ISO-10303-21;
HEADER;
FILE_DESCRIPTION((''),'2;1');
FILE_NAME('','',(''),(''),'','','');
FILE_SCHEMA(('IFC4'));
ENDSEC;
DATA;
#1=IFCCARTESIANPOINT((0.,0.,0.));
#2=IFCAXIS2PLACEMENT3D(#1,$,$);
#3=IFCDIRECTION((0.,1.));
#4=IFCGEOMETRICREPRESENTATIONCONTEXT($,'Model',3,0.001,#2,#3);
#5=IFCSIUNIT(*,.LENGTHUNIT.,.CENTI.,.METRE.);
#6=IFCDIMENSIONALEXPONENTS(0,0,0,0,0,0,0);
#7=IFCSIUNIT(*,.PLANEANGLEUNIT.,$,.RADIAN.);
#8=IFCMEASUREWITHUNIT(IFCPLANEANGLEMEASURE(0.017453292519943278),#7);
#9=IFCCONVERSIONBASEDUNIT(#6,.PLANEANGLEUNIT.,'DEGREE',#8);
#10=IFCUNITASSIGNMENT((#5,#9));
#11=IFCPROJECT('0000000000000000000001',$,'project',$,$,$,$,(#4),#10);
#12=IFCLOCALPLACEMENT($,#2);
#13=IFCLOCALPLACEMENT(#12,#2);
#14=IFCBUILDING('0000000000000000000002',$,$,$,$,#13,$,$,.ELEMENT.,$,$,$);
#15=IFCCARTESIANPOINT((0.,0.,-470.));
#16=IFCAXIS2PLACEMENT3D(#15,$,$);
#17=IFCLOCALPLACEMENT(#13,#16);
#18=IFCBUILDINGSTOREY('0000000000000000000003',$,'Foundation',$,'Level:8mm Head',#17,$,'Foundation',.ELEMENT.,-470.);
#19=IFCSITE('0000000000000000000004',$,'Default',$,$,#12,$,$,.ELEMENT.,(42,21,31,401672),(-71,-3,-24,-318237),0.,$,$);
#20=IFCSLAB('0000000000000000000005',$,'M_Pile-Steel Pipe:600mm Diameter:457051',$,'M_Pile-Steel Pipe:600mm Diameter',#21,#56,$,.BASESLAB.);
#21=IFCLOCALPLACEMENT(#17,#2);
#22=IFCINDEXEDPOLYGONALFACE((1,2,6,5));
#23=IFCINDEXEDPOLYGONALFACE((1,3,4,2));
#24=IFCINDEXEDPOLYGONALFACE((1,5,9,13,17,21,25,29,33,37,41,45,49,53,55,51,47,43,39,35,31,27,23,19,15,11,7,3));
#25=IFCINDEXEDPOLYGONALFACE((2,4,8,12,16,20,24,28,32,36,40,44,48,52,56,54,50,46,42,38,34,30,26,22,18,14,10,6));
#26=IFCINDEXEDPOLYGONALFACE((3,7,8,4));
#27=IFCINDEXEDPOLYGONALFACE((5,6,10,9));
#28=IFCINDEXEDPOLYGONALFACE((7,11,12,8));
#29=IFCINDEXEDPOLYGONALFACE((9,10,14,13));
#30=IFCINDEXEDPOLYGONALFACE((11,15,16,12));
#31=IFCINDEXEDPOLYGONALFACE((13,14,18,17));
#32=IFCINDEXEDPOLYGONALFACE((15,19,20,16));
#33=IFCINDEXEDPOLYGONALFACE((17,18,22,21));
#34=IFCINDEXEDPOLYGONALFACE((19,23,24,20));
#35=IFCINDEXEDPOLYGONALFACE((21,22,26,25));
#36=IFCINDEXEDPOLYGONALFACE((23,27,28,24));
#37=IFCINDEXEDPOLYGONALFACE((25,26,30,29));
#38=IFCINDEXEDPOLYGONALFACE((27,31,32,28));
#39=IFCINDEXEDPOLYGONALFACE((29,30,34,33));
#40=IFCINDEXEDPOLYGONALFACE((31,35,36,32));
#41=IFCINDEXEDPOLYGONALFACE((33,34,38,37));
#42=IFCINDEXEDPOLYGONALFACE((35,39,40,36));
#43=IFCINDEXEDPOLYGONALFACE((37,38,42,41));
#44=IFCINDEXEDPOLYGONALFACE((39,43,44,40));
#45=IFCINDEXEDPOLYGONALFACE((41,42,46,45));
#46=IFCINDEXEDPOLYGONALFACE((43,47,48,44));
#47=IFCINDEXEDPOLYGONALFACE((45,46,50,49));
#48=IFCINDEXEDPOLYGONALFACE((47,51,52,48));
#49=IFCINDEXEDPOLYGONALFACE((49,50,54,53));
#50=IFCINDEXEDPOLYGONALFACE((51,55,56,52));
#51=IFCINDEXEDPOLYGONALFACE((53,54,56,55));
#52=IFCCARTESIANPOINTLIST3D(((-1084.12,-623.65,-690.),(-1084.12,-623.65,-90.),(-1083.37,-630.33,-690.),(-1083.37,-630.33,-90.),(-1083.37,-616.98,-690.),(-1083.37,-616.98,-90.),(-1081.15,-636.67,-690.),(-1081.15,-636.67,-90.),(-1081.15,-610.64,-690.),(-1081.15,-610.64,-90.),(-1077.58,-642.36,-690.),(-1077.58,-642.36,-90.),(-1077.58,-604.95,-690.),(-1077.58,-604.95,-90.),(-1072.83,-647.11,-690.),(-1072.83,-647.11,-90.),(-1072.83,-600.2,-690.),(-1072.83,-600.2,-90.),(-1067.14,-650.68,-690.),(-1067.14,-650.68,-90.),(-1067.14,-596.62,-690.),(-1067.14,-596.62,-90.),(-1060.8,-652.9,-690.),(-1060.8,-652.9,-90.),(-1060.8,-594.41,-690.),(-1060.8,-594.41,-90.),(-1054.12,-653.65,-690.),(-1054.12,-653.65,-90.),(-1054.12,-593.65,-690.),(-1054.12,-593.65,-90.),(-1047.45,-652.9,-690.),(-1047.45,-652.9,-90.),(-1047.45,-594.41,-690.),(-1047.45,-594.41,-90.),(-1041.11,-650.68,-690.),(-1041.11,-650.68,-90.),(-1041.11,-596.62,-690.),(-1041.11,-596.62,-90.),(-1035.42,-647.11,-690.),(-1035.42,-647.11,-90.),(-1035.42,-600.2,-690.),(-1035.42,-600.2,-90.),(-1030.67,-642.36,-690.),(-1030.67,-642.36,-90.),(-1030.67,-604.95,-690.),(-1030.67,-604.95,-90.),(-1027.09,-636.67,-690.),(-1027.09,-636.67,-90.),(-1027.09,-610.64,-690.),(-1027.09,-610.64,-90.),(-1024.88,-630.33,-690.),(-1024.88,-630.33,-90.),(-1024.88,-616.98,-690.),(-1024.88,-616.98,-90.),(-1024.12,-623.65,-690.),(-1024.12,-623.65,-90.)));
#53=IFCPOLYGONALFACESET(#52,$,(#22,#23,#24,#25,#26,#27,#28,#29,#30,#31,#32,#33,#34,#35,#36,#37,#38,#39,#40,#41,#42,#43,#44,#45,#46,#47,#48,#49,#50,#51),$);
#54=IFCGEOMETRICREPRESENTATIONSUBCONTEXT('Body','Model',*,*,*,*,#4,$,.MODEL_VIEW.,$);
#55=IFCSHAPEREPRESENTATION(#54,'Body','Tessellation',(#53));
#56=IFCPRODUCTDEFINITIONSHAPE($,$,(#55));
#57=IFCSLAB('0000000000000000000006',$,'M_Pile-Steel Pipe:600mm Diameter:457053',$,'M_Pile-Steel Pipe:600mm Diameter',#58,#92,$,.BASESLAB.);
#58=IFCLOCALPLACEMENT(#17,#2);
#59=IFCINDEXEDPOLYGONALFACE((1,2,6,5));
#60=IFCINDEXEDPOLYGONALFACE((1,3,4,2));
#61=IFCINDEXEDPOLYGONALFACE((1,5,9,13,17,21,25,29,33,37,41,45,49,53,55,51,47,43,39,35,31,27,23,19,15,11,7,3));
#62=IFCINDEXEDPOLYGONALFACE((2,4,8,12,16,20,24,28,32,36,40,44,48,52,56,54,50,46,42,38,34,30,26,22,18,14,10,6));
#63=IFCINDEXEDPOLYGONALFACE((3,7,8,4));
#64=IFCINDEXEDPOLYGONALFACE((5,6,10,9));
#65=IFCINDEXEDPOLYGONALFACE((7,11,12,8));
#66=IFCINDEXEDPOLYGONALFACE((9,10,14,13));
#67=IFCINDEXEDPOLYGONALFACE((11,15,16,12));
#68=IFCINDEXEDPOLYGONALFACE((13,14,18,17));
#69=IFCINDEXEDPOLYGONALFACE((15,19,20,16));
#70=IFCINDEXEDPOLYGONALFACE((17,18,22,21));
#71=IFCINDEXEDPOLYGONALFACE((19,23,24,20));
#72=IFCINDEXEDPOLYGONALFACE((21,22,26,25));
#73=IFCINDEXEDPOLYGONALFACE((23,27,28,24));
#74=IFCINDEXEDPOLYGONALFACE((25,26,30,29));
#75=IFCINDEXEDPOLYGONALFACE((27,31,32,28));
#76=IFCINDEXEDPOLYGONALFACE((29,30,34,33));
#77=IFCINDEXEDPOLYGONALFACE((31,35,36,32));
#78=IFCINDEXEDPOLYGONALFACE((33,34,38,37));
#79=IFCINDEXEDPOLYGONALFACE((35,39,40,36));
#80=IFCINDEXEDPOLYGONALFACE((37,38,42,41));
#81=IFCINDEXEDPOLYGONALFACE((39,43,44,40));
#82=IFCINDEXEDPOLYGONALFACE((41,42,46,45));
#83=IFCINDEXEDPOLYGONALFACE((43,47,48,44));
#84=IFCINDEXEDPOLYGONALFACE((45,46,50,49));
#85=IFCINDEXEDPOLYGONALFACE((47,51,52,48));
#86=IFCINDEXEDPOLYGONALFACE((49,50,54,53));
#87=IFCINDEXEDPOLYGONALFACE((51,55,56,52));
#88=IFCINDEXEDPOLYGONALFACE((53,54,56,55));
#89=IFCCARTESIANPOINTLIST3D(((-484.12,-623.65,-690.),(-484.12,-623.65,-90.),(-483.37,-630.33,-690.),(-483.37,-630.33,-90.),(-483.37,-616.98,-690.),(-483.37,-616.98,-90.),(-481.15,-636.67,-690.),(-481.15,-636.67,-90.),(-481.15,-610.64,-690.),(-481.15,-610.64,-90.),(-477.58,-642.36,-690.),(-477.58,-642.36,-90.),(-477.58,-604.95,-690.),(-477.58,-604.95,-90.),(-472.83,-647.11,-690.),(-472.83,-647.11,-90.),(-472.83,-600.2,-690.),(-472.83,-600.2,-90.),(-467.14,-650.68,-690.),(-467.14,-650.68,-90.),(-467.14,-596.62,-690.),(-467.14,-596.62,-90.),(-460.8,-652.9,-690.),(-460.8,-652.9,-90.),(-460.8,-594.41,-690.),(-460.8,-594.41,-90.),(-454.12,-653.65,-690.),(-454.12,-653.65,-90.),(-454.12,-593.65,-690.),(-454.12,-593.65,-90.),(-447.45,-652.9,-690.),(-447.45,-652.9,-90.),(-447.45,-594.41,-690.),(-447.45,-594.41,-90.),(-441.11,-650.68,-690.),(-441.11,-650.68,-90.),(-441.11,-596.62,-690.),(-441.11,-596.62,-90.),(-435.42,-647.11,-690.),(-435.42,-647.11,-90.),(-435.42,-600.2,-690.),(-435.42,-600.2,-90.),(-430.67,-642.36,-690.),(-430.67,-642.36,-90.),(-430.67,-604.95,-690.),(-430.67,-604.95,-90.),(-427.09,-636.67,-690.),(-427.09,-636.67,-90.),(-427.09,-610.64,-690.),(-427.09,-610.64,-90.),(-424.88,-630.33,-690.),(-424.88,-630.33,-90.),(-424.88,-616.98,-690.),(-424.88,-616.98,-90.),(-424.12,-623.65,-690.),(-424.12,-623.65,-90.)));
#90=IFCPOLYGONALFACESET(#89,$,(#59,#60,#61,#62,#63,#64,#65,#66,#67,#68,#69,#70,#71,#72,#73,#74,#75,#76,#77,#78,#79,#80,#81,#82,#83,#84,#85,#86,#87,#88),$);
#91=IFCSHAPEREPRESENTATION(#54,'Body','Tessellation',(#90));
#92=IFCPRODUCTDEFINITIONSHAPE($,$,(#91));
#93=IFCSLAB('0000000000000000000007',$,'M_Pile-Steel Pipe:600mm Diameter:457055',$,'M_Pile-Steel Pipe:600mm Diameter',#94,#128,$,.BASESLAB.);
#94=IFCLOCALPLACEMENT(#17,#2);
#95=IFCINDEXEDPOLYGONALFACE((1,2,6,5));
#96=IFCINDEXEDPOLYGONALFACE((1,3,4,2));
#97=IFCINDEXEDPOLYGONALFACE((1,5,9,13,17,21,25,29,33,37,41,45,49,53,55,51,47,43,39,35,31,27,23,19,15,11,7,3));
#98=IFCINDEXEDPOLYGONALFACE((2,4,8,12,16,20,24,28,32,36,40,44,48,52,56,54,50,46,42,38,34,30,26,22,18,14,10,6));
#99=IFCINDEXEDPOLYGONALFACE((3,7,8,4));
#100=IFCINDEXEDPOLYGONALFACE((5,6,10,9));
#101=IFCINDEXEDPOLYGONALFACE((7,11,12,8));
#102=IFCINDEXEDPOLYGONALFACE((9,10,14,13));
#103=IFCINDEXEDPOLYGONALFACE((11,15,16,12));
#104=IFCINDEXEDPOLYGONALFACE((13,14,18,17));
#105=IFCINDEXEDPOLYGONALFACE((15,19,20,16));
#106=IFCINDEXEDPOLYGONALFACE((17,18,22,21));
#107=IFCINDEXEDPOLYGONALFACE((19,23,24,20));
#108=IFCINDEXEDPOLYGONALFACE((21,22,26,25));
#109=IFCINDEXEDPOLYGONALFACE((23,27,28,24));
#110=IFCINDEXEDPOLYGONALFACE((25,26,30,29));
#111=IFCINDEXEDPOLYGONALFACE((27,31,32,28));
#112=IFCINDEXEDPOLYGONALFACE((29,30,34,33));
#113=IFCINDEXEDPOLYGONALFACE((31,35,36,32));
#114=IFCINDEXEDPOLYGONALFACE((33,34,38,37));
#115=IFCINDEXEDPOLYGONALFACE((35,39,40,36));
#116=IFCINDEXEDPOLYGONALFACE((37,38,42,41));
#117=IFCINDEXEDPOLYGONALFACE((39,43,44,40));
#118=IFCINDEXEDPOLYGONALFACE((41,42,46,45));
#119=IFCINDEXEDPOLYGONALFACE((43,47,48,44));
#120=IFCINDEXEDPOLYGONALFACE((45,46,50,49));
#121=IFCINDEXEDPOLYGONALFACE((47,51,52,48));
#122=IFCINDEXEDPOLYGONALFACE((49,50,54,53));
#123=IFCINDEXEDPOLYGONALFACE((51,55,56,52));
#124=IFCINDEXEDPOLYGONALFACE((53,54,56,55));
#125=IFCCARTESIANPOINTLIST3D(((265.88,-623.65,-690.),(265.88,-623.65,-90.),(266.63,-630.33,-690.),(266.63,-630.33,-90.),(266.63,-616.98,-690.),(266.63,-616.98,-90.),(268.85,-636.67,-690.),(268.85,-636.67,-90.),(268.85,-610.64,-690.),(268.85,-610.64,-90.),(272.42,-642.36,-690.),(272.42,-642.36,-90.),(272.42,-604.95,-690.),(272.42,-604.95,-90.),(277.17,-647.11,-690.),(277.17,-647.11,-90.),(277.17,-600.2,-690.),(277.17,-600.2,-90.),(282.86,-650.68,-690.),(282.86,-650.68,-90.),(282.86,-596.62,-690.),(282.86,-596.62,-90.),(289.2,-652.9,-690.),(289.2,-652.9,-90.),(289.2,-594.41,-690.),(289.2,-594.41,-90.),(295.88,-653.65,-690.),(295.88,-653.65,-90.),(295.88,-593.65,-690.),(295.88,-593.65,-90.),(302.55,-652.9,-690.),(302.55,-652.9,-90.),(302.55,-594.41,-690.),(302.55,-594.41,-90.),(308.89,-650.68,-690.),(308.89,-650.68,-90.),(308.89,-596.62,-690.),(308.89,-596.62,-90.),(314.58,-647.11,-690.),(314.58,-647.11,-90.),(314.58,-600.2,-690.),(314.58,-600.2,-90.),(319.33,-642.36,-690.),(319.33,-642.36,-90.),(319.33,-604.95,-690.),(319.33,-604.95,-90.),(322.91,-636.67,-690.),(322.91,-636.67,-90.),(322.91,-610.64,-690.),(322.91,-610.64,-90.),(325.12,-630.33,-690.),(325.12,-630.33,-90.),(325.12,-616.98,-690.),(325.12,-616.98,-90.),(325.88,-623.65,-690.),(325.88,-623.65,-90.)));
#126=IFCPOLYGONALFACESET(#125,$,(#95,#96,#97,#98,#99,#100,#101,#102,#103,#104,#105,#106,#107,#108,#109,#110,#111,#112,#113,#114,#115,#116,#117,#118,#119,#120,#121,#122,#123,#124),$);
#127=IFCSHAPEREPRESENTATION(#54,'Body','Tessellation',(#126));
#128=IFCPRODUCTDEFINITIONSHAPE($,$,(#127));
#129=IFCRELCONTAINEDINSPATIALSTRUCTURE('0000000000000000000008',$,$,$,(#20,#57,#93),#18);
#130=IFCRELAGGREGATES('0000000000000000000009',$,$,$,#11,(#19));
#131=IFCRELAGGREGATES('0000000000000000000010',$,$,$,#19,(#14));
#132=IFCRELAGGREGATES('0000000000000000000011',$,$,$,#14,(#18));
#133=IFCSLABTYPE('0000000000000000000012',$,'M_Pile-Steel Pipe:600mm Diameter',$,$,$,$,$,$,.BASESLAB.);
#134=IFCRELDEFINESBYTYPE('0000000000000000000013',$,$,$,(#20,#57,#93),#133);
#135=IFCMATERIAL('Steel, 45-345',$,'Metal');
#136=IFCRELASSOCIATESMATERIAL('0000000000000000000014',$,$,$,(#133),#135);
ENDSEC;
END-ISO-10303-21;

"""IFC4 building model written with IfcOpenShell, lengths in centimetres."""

from ifc_helpers import new_model, entity, si_unit, converted_unit, direction, frame, origin, place, context, subcontext, project, spatial, arc, indexed_curve, outline, extrude, material, type_object, element, save


model = new_model("IFC4")

# Units and contexts
model_context = context("Model", 3, precision=0.001, world=origin(), true_north=direction((0.0, 1.0)))
body_context = subcontext(model_context, "Body", "Model", "MODEL_VIEW")
ifc_project = project(units=[si_unit("LENGTHUNIT", "METRE", prefix="CENTI"), converted_unit("PLANEANGLEUNIT", "DEGREE", entity("IfcPlaneAngleMeasure", 0.017453292519943278), si_unit("PLANEANGLEUNIT", "RADIAN"), dimensions=[0, 0, 0, 0, 0, 0, 0])], contexts=[model_context])

# Site, building, storey
site_placement = place(None, origin())
site = spatial("IfcSite", under=ifc_project, at=site_placement, Name="Default", CompositionType="ELEMENT", RefLatitude=(42, 21, 31, 401672), RefLongitude=(-71, -3, -24, -318237), RefElevation=0.0)
building_placement = place(site_placement, origin())
building = spatial("IfcBuilding", under=site, at=building_placement, CompositionType="ELEMENT")
storey_placement = place(building_placement, frame((0.0, 0.0, -470.0)))
storey = spatial("IfcBuildingStorey", under=building, at=storey_placement, Name="Foundation", ObjectType="Level:8mm Head", LongName="Foundation", CompositionType="ELEMENT", Elevation=-470.0)

# Slabs
ifc_material_1 = material(Name="Steel, 45-345", Category="Metal")
slab_type_1 = type_object("IfcSlabType", Name="M_Pile-Steel Pipe:600mm Diameter", PredefinedType="BASESLAB", material=ifc_material_1)
slab_1_placement = place(storey_placement, origin())
element("IfcSlab", 1, at=slab_1_placement, inside=storey, type_object=slab_type_1, Name="M_Pile-Steel Pipe:600mm Diameter:457051", ObjectType="M_Pile-Steel Pipe:600mm Diameter", PredefinedType="BASESLAB", context=body_context, shape_type="SweptSolid", body=[
    extrude(outline(indexed_curve([(-30.0, 0.0), (0.0, -30.0), (30.0, 0.0), (0.0, 30.0)], segments=[arc(1, 2, 3), arc(3, 4, 1)], self_intersect=False)), frame((-1054.12, -623.65, -690.0)), (0.0, 0.0, 1.0), 600.0),
])
slab_2_placement = place(storey_placement, origin())
element("IfcSlab", 2, at=slab_2_placement, inside=storey, type_object=slab_type_1, Name="M_Pile-Steel Pipe:600mm Diameter:457053", ObjectType="M_Pile-Steel Pipe:600mm Diameter", PredefinedType="BASESLAB", context=body_context, shape_type="SweptSolid", body=[
    extrude(outline(indexed_curve([(-30.0, 0.0), (0.0, -30.0), (30.0, 0.0), (0.0, 30.0)], segments=[arc(1, 2, 3), arc(3, 4, 1)], self_intersect=False)), frame((-454.12, -623.65, -690.0)), (0.0, 0.0, 1.0), 600.0),
])
slab_3_placement = place(storey_placement, origin())
element("IfcSlab", 3, at=slab_3_placement, inside=storey, type_object=slab_type_1, Name="M_Pile-Steel Pipe:600mm Diameter:457055", ObjectType="M_Pile-Steel Pipe:600mm Diameter", PredefinedType="BASESLAB", context=body_context, shape_type="SweptSolid", body=[
    extrude(outline(indexed_curve([(-30.0, 0.0), (0.0, -30.0), (30.0, 0.0), (0.0, 30.0)], segments=[arc(1, 2, 3), arc(3, 4, 1)], self_intersect=False)), frame((295.88, -623.65, -690.0)), (0.0, 0.0, 1.0), 600.0),
])

save(model, "model.ifc")
